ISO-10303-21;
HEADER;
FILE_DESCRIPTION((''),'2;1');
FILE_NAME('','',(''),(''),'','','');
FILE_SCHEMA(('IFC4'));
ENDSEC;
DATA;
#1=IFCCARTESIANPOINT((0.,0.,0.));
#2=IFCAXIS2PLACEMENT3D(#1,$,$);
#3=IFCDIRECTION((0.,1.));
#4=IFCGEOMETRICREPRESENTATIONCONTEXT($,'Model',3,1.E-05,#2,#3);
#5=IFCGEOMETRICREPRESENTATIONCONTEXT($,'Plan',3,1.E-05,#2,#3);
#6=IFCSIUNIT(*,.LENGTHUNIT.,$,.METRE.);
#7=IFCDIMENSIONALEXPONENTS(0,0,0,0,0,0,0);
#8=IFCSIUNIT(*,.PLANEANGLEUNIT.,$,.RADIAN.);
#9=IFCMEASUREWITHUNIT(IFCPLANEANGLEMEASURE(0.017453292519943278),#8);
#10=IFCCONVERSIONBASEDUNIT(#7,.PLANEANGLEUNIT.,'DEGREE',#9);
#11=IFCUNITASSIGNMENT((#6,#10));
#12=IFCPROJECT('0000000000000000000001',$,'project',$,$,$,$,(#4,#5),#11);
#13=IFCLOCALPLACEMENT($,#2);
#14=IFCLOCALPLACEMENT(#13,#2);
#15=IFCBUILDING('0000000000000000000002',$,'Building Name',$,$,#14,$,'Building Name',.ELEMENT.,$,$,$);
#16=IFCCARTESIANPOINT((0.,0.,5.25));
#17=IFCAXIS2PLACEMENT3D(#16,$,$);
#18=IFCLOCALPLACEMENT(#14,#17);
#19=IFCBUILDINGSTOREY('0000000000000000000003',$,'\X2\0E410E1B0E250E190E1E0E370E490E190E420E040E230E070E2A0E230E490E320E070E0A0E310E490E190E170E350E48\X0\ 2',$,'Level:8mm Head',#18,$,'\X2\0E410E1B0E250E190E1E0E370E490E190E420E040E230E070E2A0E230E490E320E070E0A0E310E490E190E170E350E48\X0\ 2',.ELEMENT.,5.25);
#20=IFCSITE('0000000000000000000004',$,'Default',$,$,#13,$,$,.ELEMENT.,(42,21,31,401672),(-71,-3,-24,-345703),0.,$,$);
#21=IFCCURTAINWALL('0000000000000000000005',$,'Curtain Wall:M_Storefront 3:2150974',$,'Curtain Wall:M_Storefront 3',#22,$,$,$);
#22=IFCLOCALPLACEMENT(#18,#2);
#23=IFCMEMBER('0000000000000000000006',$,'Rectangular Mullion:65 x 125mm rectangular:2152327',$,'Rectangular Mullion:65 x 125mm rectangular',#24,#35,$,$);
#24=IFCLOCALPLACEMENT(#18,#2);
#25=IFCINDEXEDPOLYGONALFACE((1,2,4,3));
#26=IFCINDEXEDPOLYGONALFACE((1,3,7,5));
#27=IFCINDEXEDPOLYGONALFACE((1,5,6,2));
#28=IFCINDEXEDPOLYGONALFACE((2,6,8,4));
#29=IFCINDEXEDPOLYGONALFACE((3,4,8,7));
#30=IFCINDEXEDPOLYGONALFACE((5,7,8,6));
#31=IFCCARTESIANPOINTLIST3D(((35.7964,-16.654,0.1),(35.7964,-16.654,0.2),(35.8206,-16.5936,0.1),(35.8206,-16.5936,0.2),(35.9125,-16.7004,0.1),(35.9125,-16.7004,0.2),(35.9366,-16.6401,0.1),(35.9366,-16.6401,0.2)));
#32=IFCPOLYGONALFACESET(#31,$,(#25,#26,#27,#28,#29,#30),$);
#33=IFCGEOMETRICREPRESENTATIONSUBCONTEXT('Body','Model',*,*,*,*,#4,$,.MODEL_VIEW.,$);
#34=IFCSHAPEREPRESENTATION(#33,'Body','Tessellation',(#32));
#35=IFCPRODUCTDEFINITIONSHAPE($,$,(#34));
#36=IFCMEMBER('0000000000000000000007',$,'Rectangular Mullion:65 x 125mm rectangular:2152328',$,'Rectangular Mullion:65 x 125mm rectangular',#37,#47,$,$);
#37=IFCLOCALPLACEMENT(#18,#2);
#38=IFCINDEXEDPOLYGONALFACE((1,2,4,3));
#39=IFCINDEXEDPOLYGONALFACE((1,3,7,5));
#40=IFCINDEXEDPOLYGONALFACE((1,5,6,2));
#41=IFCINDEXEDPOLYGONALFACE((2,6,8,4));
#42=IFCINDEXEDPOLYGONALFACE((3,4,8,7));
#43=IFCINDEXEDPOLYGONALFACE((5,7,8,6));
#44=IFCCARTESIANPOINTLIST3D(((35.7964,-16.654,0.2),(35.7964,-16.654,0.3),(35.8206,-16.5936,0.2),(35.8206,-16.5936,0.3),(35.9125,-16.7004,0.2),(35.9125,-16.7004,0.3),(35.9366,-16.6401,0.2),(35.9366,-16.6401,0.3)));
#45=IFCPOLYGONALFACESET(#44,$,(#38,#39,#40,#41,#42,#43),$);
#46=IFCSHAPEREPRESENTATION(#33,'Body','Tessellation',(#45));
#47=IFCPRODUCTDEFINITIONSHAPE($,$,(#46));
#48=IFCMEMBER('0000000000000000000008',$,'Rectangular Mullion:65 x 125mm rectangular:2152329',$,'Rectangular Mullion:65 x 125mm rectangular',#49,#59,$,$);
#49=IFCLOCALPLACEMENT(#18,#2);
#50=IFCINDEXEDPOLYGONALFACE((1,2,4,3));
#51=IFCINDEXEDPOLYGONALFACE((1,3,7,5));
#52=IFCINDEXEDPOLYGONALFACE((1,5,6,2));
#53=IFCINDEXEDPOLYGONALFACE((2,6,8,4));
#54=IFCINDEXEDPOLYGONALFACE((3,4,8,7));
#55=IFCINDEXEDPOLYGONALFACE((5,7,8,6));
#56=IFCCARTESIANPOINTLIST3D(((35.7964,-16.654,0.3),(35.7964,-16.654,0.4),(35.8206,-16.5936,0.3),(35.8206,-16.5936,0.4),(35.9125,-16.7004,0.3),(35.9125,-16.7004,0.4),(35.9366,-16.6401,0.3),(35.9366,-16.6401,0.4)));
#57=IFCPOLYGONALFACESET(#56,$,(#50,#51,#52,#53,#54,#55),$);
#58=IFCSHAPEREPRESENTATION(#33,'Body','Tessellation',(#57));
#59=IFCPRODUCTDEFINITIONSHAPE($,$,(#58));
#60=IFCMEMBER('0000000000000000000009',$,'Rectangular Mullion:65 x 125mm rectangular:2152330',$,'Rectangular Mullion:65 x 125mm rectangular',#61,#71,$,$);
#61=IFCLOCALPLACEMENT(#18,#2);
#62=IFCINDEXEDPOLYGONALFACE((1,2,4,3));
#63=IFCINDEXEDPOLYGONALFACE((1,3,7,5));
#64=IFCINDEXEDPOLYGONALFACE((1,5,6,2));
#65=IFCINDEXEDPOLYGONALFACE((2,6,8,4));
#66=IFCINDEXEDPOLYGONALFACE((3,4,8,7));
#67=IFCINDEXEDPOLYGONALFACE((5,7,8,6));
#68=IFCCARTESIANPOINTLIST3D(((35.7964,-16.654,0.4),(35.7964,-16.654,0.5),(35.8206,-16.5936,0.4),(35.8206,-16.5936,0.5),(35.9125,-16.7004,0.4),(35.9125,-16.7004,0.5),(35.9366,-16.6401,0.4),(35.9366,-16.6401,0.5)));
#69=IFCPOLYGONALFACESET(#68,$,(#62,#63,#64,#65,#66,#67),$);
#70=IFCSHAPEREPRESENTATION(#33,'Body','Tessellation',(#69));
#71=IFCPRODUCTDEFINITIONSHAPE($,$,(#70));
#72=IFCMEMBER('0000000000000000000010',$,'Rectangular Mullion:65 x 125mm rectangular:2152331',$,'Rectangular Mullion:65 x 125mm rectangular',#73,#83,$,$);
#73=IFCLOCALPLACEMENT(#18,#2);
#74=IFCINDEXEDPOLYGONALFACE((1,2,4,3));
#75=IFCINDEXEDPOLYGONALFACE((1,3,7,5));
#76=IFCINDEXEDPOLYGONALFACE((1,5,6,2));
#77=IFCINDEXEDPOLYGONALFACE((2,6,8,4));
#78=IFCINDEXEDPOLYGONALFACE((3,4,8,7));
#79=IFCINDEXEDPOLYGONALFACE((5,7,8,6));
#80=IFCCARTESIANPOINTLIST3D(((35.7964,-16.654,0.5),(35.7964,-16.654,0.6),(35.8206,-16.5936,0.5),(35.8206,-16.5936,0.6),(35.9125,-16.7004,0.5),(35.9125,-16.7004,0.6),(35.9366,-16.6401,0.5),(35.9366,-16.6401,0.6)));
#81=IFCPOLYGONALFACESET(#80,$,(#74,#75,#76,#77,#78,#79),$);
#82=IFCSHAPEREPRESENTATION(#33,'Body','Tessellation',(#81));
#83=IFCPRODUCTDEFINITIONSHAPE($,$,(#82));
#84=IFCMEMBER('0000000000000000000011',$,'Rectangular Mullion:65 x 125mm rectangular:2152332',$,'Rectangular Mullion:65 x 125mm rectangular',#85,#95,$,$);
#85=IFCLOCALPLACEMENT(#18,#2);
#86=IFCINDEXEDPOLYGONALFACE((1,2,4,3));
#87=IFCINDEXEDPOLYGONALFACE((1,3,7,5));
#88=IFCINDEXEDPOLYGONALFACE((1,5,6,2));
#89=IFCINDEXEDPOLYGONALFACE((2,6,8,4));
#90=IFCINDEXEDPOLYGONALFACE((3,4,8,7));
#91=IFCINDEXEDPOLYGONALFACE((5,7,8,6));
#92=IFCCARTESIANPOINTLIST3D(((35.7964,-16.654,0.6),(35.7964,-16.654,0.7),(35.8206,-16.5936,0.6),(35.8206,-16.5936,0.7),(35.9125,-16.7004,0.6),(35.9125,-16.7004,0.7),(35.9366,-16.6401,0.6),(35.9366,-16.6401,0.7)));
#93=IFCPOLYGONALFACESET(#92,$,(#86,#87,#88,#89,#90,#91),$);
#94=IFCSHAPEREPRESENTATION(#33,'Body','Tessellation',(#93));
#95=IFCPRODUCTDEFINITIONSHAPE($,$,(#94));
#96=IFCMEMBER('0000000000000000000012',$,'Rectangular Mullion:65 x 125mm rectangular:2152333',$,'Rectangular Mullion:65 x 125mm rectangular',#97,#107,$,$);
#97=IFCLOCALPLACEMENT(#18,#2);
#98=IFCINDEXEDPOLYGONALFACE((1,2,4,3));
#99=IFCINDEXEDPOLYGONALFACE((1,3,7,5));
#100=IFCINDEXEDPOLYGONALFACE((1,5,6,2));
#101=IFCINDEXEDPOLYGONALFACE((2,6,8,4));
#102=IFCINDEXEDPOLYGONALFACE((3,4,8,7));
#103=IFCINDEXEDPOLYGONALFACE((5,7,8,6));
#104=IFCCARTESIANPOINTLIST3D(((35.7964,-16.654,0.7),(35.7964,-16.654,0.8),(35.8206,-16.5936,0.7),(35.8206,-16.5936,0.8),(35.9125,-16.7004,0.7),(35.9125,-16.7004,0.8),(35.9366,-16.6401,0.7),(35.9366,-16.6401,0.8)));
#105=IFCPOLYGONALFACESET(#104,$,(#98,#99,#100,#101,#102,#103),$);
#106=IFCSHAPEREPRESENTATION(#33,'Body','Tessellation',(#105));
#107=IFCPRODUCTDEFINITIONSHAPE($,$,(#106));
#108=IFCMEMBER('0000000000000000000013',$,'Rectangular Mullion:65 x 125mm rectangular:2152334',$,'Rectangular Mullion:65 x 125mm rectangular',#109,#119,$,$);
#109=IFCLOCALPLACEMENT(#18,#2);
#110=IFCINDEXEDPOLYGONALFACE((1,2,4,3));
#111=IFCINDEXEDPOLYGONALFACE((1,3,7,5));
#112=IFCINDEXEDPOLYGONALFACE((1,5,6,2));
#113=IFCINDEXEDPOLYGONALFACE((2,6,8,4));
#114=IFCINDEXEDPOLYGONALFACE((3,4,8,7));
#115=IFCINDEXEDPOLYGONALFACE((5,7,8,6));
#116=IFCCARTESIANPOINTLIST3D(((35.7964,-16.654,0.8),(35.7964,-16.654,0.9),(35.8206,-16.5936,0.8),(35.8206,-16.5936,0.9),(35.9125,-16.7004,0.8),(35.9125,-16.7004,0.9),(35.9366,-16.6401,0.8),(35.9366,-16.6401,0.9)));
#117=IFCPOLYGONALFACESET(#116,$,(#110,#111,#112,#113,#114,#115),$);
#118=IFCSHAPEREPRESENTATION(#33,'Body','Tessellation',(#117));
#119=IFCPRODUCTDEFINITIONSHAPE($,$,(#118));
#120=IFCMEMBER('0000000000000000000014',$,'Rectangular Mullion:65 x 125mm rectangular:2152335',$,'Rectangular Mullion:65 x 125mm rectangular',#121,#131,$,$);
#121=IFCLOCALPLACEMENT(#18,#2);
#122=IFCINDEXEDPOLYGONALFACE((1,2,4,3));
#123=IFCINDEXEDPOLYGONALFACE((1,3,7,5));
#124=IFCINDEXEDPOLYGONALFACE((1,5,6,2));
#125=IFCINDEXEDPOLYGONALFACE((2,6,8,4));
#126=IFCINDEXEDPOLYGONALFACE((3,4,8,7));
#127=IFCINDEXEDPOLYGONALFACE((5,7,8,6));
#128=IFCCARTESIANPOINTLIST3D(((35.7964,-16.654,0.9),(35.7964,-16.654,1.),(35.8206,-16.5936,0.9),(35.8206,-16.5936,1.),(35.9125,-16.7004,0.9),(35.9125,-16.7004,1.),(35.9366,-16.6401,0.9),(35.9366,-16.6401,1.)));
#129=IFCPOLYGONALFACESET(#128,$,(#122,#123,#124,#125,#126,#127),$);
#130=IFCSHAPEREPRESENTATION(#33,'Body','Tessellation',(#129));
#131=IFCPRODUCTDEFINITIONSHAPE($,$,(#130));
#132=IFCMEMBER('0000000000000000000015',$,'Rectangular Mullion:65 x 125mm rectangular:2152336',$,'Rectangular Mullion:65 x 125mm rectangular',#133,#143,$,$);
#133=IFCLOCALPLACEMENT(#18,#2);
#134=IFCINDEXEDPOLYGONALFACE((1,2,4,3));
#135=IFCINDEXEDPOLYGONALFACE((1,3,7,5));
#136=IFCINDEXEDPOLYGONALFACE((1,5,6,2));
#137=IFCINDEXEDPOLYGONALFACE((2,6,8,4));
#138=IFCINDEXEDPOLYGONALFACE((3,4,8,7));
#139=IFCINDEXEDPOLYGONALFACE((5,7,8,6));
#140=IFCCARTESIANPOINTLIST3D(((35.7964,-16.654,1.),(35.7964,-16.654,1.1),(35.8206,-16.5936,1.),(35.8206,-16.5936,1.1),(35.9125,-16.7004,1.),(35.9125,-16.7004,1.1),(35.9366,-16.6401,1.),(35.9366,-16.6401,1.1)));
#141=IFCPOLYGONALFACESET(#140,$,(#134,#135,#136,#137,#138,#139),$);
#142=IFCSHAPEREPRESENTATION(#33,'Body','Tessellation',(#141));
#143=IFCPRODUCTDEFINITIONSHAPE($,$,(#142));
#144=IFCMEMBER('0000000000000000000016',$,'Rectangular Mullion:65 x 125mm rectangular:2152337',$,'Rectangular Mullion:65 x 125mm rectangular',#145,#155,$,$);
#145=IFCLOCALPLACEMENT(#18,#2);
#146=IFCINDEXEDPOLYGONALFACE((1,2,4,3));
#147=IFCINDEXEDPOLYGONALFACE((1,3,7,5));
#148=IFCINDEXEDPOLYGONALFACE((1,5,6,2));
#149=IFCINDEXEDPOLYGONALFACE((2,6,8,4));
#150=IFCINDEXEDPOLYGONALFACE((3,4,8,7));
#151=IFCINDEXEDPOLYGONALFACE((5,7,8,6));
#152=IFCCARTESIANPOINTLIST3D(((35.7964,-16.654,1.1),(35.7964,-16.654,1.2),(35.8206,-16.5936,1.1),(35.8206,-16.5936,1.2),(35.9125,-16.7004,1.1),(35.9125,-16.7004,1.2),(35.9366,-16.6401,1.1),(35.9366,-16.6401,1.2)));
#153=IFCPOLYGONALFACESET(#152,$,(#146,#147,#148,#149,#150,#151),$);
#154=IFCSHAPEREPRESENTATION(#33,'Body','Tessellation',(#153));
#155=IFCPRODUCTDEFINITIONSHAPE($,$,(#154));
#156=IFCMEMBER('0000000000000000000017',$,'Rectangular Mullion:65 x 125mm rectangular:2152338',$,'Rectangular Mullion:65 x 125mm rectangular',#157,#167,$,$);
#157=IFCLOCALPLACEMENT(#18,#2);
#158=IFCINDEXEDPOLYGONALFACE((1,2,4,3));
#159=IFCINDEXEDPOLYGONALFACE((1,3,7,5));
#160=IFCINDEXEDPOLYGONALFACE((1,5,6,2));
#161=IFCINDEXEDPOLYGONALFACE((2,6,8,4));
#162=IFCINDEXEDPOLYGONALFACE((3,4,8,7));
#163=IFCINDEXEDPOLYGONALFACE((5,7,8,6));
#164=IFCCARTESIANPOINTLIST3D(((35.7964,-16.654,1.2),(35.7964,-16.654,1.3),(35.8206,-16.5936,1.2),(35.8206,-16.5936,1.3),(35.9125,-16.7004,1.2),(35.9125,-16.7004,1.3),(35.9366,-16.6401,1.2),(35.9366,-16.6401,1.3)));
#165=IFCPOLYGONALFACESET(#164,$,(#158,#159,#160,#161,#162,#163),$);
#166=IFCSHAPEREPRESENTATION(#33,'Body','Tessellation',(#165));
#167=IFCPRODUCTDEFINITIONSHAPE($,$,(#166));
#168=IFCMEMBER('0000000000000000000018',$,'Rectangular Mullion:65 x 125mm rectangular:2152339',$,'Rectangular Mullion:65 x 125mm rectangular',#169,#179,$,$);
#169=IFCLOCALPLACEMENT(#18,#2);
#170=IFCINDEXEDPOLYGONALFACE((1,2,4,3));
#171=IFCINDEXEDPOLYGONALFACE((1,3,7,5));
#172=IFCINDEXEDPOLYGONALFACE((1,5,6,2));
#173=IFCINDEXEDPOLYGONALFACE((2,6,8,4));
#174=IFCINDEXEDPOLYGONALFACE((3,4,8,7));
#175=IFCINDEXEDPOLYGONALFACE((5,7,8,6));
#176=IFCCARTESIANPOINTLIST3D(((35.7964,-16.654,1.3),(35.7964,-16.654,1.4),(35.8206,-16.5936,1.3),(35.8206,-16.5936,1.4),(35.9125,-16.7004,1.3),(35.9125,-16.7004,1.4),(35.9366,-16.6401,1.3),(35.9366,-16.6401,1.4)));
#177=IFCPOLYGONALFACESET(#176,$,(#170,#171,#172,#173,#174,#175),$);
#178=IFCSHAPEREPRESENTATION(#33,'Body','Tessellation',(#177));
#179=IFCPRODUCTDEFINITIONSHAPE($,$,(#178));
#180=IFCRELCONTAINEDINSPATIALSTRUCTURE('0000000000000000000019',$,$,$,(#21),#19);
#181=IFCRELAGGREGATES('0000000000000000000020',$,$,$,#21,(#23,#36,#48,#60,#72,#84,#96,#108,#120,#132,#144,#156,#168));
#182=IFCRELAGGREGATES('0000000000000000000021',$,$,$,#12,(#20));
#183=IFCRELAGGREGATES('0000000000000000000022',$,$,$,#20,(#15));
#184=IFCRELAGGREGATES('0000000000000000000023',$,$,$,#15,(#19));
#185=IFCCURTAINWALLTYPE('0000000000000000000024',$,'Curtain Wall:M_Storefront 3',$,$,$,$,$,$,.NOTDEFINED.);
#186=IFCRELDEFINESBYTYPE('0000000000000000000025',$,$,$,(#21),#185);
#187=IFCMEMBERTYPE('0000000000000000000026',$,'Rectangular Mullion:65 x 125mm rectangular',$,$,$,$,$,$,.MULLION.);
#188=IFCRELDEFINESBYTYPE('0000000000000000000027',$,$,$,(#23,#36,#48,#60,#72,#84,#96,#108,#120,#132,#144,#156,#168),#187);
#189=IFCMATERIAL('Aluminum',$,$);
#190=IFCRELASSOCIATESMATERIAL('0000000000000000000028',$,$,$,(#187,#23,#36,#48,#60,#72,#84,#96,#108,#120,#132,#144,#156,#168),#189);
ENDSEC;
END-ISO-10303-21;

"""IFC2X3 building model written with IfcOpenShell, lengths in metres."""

from ifc_helpers import new_model, entity, si_unit, converted_unit, direction, frame, origin, origin_2d_with_axis, place, context, subcontext, project, spatial, rectangle, extrude, source, transform, mapped, material, type_object, type_shapes, element, aggregate, save


model = new_model("IFC2X3")

# Units and contexts
model_context = context("Model", 3, precision=1e-05, world=origin(), true_north=direction((0.0, 1.0)))
plan_context = context("Plan", 3, precision=1e-05, world=origin(), true_north=direction((0.0, 1.0)))
body_context = subcontext(model_context, "Body", "Model", "MODEL_VIEW")
ifc_project = project(units=[si_unit("LENGTHUNIT", "METRE"), converted_unit("PLANEANGLEUNIT", "DEGREE", entity("IfcPlaneAngleMeasure", 0.017453292519943278), si_unit("PLANEANGLEUNIT", "RADIAN"), dimensions=[0, 0, 0, 0, 0, 0, 0])], contexts=[model_context, plan_context])

# Site, building, storey
site_placement = place(None, origin())
site = spatial("IfcSite", under=ifc_project, at=site_placement, Name="Default", CompositionType="ELEMENT", RefLatitude=(42, 21, 31, 401672), RefLongitude=(-71, -3, -24, -345703), RefElevation=0.0)
building_placement = place(site_placement, origin())
building = spatial("IfcBuilding", under=site, at=building_placement, Name="Building Name", LongName="Building Name", CompositionType="ELEMENT")
storey_placement = place(building_placement, frame((0.0, 0.0, 5.25)))
storey = spatial("IfcBuildingStorey", under=building, at=storey_placement, Name="แปลนพื้นโครงสร้างชั้นที่ 2", ObjectType="Level:8mm Head", LongName="แปลนพื้นโครงสร้างชั้นที่ 2", CompositionType="ELEMENT", Elevation=5.25)

# Curtain wall, members
curtain_wall_type = type_object("IfcCurtainWallType", Name="Curtain Wall:M_Storefront 3", PredefinedType="NOTDEFINED")
ifc_material_1 = material(Name="Aluminum")
curtain_wall_1_placement = place(storey_placement, frame((0.0, 0.0, -5.25)))
curtain_wall_1 = element("IfcCurtainWall", 1, at=curtain_wall_1_placement, inside=storey, type_object=curtain_wall_type, Name="Curtain Wall:M_Storefront 3:2150974", ObjectType="Curtain Wall:M_Storefront 3")
member_type_1 = type_object("IfcMemberType", Name="Rectangular Mullion:65 x 125mm rectangular", PredefinedType="MULLION", material=ifc_material_1)
shared_shape_1 = source(origin(), body_context, "Body", "SweptSolid", [
    extrude(rectangle(XDim=0.065, YDim=0.125, at=origin_2d_with_axis()), frame((-0.0325, 0.0, -0.1), z_axis=(0.0, 0.0, 1.0), x_axis=(-1.0, 0.0, 0.0)), (0.0, 0.0, 1.0), 0.1),
])
type_shapes(member_type_1, [shared_shape_1])
member_1_placement = place(curtain_wall_1_placement, frame((35.8545, -16.6772, 5.45), z_axis=(0.0, 0.0, 1.0), x_axis=(-0.371573, -0.928404, 0.0)))
member_1 = element("IfcMember", 2, at=member_1_placement, type_object=member_type_1, material=ifc_material_1, Name="Rectangular Mullion:65 x 125mm rectangular:2152327", ObjectType="Rectangular Mullion:65 x 125mm rectangular", context=body_context, shape_type="MappedRepresentation", body=[
    mapped(shared_shape_1, transform((0.0, 0.0, 0.0), scale=1.0)),
])
member_2_placement = place(curtain_wall_1_placement, frame((35.8545, -16.6772, 5.55), z_axis=(0.0, 0.0, 1.0), x_axis=(-0.371573, -0.928404, 0.0)))
member_2 = element("IfcMember", 3, at=member_2_placement, type_object=member_type_1, material=ifc_material_1, Name="Rectangular Mullion:65 x 125mm rectangular:2152328", ObjectType="Rectangular Mullion:65 x 125mm rectangular", context=body_context, shape_type="MappedRepresentation", body=[
    mapped(shared_shape_1, transform((0.0, 0.0, 0.0), scale=1.0)),
])
member_3_placement = place(curtain_wall_1_placement, frame((35.8545, -16.6772, 5.65), z_axis=(0.0, 0.0, 1.0), x_axis=(-0.371573, -0.928404, 0.0)))
member_3 = element("IfcMember", 4, at=member_3_placement, type_object=member_type_1, material=ifc_material_1, Name="Rectangular Mullion:65 x 125mm rectangular:2152329", ObjectType="Rectangular Mullion:65 x 125mm rectangular", context=body_context, shape_type="MappedRepresentation", body=[
    mapped(shared_shape_1, transform((0.0, 0.0, 0.0), scale=1.0)),
])
member_4_placement = place(curtain_wall_1_placement, frame((35.8545, -16.6772, 5.75), z_axis=(0.0, 0.0, 1.0), x_axis=(-0.371573, -0.928404, 0.0)))
member_4 = element("IfcMember", 5, at=member_4_placement, type_object=member_type_1, material=ifc_material_1, Name="Rectangular Mullion:65 x 125mm rectangular:2152330", ObjectType="Rectangular Mullion:65 x 125mm rectangular", context=body_context, shape_type="MappedRepresentation", body=[
    mapped(shared_shape_1, transform((0.0, 0.0, 0.0), scale=1.0)),
])
member_5_placement = place(curtain_wall_1_placement, frame((35.8545, -16.6772, 5.85), z_axis=(0.0, 0.0, 1.0), x_axis=(-0.371573, -0.928404, 0.0)))
member_5 = element("IfcMember", 6, at=member_5_placement, type_object=member_type_1, material=ifc_material_1, Name="Rectangular Mullion:65 x 125mm rectangular:2152331", ObjectType="Rectangular Mullion:65 x 125mm rectangular", context=body_context, shape_type="MappedRepresentation", body=[
    mapped(shared_shape_1, transform((0.0, 0.0, 0.0), scale=1.0)),
])
member_6_placement = place(curtain_wall_1_placement, frame((35.8545, -16.6772, 5.95), z_axis=(0.0, 0.0, 1.0), x_axis=(-0.371573, -0.928404, 0.0)))
member_6 = element("IfcMember", 7, at=member_6_placement, type_object=member_type_1, material=ifc_material_1, Name="Rectangular Mullion:65 x 125mm rectangular:2152332", ObjectType="Rectangular Mullion:65 x 125mm rectangular", context=body_context, shape_type="MappedRepresentation", body=[
    mapped(shared_shape_1, transform((0.0, 0.0, 0.0), scale=1.0)),
])
member_7_placement = place(curtain_wall_1_placement, frame((35.8545, -16.6772, 6.05), z_axis=(0.0, 0.0, 1.0), x_axis=(-0.371573, -0.928404, 0.0)))
member_7 = element("IfcMember", 8, at=member_7_placement, type_object=member_type_1, material=ifc_material_1, Name="Rectangular Mullion:65 x 125mm rectangular:2152333", ObjectType="Rectangular Mullion:65 x 125mm rectangular", context=body_context, shape_type="MappedRepresentation", body=[
    mapped(shared_shape_1, transform((0.0, 0.0, 0.0), scale=1.0)),
])
member_8_placement = place(curtain_wall_1_placement, frame((35.8545, -16.6772, 6.15), z_axis=(0.0, 0.0, 1.0), x_axis=(-0.371573, -0.928404, 0.0)))
member_8 = element("IfcMember", 9, at=member_8_placement, type_object=member_type_1, material=ifc_material_1, Name="Rectangular Mullion:65 x 125mm rectangular:2152334", ObjectType="Rectangular Mullion:65 x 125mm rectangular", context=body_context, shape_type="MappedRepresentation", body=[
    mapped(shared_shape_1, transform((0.0, 0.0, 0.0), scale=1.0)),
])
member_9_placement = place(curtain_wall_1_placement, frame((35.8545, -16.6772, 6.25), z_axis=(0.0, 0.0, 1.0), x_axis=(-0.371573, -0.928404, 0.0)))
member_9 = element("IfcMember", 10, at=member_9_placement, type_object=member_type_1, material=ifc_material_1, Name="Rectangular Mullion:65 x 125mm rectangular:2152335", ObjectType="Rectangular Mullion:65 x 125mm rectangular", context=body_context, shape_type="MappedRepresentation", body=[
    mapped(shared_shape_1, transform((0.0, 0.0, 0.0), scale=1.0)),
])
member_10_placement = place(curtain_wall_1_placement, frame((35.8545, -16.6772, 6.35), z_axis=(0.0, 0.0, 1.0), x_axis=(-0.371573, -0.928404, 0.0)))
member_10 = element("IfcMember", 11, at=member_10_placement, type_object=member_type_1, material=ifc_material_1, Name="Rectangular Mullion:65 x 125mm rectangular:2152336", ObjectType="Rectangular Mullion:65 x 125mm rectangular", context=body_context, shape_type="MappedRepresentation", body=[
    mapped(shared_shape_1, transform((0.0, 0.0, 0.0), scale=1.0)),
])
member_11_placement = place(curtain_wall_1_placement, frame((35.8545, -16.6772, 6.45), z_axis=(0.0, 0.0, 1.0), x_axis=(-0.371573, -0.928404, 0.0)))
member_11 = element("IfcMember", 12, at=member_11_placement, type_object=member_type_1, material=ifc_material_1, Name="Rectangular Mullion:65 x 125mm rectangular:2152337", ObjectType="Rectangular Mullion:65 x 125mm rectangular", context=body_context, shape_type="MappedRepresentation", body=[
    mapped(shared_shape_1, transform((0.0, 0.0, 0.0), scale=1.0)),
])
member_12_placement = place(curtain_wall_1_placement, frame((35.8545, -16.6772, 6.55), z_axis=(0.0, 0.0, 1.0), x_axis=(-0.371573, -0.928404, 0.0)))
member_12 = element("IfcMember", 13, at=member_12_placement, type_object=member_type_1, material=ifc_material_1, Name="Rectangular Mullion:65 x 125mm rectangular:2152338", ObjectType="Rectangular Mullion:65 x 125mm rectangular", context=body_context, shape_type="MappedRepresentation", body=[
    mapped(shared_shape_1, transform((0.0, 0.0, 0.0), scale=1.0)),
])
member_13_placement = place(curtain_wall_1_placement, frame((35.8545, -16.6772, 6.65), z_axis=(0.0, 0.0, 1.0), x_axis=(-0.371573, -0.928404, 0.0)))
member_13 = element("IfcMember", 14, at=member_13_placement, type_object=member_type_1, material=ifc_material_1, Name="Rectangular Mullion:65 x 125mm rectangular:2152339", ObjectType="Rectangular Mullion:65 x 125mm rectangular", context=body_context, shape_type="MappedRepresentation", body=[
    mapped(shared_shape_1, transform((0.0, 0.0, 0.0), scale=1.0)),
])
aggregate(curtain_wall_1, [member_1, member_2, member_3, member_4, member_5, member_6, member_7, member_8, member_9, member_10, member_11, member_12, member_13])

save(model, "model.ifc")
